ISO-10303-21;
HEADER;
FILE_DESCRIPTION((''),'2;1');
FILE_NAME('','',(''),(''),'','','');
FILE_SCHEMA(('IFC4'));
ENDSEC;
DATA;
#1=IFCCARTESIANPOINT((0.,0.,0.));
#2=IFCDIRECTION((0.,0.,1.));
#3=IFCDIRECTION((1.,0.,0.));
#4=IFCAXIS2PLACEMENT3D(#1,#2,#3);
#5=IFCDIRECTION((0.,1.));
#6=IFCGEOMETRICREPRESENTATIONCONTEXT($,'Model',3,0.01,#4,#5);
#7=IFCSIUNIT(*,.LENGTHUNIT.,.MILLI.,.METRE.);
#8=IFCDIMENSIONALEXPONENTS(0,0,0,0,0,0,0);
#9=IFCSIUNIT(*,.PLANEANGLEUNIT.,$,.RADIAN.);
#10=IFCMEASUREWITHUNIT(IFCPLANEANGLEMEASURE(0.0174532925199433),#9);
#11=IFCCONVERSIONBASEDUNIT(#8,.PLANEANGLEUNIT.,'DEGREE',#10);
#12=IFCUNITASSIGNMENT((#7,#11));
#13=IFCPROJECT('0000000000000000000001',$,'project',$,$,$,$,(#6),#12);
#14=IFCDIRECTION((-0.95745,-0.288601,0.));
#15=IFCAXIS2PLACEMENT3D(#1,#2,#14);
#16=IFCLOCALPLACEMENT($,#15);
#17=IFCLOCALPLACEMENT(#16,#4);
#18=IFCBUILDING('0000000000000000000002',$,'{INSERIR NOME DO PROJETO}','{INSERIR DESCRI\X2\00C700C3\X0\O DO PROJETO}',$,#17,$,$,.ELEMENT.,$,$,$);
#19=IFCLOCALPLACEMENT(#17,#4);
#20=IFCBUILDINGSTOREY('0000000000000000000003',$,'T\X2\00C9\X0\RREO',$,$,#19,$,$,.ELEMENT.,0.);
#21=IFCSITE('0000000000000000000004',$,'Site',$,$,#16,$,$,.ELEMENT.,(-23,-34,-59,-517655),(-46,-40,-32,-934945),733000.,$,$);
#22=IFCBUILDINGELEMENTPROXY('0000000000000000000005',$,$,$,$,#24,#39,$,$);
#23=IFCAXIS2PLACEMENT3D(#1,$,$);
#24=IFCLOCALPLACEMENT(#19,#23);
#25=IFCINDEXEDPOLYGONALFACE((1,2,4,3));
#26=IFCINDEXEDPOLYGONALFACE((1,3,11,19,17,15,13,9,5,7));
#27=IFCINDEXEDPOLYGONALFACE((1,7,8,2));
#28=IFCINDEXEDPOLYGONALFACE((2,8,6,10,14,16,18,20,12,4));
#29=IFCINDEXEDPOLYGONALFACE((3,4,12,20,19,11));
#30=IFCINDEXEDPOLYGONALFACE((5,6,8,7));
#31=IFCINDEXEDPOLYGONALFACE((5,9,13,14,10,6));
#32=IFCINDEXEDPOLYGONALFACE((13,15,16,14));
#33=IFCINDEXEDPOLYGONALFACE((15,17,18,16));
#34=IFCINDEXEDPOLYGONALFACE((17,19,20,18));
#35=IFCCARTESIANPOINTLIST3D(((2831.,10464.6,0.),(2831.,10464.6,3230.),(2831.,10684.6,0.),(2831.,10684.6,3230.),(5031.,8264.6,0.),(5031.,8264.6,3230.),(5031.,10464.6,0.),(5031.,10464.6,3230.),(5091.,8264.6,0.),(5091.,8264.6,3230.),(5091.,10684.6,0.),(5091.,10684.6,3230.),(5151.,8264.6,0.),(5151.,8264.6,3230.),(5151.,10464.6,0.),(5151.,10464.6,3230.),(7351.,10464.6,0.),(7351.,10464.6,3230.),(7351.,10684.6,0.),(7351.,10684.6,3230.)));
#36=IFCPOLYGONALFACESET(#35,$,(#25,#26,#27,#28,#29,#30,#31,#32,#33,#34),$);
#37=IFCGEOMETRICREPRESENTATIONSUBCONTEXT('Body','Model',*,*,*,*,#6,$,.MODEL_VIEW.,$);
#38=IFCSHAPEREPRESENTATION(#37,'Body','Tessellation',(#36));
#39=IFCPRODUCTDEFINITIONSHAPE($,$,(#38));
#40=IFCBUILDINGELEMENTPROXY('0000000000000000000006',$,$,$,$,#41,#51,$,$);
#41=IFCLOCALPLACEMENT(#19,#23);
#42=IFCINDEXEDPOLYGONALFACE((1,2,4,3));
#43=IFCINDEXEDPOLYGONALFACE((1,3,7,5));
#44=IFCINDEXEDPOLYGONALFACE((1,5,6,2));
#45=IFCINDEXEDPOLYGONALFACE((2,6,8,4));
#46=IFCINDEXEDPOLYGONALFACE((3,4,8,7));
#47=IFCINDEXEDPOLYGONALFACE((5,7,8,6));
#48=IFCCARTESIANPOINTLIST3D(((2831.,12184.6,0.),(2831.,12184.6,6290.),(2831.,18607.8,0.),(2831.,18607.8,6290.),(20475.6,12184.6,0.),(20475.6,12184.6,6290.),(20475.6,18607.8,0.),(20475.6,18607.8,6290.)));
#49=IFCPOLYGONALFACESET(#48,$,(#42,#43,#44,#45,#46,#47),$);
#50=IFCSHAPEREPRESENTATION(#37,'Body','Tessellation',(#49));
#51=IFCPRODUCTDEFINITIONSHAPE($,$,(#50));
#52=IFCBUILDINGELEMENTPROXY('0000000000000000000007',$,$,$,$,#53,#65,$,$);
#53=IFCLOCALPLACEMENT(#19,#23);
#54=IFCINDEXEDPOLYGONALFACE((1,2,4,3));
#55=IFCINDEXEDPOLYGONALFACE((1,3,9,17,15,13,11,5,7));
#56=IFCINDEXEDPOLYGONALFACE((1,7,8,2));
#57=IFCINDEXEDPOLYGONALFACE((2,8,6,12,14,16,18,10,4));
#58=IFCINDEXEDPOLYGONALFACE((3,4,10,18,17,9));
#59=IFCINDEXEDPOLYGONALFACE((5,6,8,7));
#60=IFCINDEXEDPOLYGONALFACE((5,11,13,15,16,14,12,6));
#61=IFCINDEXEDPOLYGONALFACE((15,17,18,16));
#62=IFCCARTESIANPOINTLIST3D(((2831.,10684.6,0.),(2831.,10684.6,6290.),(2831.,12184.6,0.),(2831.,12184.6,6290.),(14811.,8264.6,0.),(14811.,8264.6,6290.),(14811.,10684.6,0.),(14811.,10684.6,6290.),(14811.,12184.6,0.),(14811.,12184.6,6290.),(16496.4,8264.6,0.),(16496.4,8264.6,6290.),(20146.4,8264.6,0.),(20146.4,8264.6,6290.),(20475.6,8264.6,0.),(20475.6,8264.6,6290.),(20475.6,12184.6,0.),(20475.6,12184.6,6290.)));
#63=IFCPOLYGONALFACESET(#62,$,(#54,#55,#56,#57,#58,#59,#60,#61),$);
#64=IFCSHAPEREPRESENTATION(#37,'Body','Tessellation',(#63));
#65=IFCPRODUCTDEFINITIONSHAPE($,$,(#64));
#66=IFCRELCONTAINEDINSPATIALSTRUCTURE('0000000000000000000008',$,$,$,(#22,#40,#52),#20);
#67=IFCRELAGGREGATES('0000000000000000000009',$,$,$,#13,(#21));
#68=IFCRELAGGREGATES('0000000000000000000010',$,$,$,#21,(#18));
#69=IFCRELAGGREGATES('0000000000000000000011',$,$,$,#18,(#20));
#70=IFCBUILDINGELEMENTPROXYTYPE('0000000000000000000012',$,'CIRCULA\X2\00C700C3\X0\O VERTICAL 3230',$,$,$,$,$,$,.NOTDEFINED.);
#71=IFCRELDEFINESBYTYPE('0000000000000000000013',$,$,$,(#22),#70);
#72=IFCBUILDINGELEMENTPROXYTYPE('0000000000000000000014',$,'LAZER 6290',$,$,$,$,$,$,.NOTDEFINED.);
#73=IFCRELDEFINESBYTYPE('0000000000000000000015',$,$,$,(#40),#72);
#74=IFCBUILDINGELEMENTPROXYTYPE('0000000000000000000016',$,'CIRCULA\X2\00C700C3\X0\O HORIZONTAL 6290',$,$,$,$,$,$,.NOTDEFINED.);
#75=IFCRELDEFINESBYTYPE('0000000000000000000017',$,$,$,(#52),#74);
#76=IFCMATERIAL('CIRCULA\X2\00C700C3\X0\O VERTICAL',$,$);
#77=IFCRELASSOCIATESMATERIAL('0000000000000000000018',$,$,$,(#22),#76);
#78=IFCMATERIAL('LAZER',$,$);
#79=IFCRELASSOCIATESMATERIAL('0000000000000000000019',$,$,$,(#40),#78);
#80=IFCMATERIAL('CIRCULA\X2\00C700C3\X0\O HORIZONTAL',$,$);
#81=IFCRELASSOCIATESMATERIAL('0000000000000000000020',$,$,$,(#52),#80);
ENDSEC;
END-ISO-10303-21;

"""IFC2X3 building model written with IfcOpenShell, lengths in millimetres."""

from ifc_helpers import new_model, entity, si_unit, converted_unit, direction, frame, origin_with_axes, place, context, subcontext, project, spatial, polyline, outline, extrude, material, type_object, element, save


model = new_model("IFC2X3")

# Units and contexts
model_context = context("Model", 3, precision=0.01, world=origin_with_axes(), true_north=direction((0.0, 1.0)))
body_context = subcontext(model_context, "Body", "Model", "MODEL_VIEW")
ifc_project = project(units=[si_unit("LENGTHUNIT", "METRE", prefix="MILLI"), converted_unit("PLANEANGLEUNIT", "DEGREE", entity("IfcPlaneAngleMeasure", 0.0174532925199433), si_unit("PLANEANGLEUNIT", "RADIAN"), dimensions=[0, 0, 0, 0, 0, 0, 0])], contexts=[model_context])

# Site, building, storey
site_placement = place(None, frame((0.0, 0.0, 0.0), z_axis=(0.0, 0.0, 1.0), x_axis=(-0.95745, -0.288601, 0.0)))
site = spatial("IfcSite", under=ifc_project, at=site_placement, Name="Site", CompositionType="ELEMENT", RefLatitude=(-23, -34, -59, -517655), RefLongitude=(-46, -40, -32, -934945), RefElevation=733000.0)
building_placement = place(site_placement, origin_with_axes())
building = spatial("IfcBuilding", under=site, at=building_placement, Name="{INSERIR NOME DO PROJETO}", Description="{INSERIR DESCRIÇÃO DO PROJETO}", CompositionType="ELEMENT")
storey_placement = place(building_placement, origin_with_axes())
storey = spatial("IfcBuildingStorey", under=building, at=storey_placement, Name="TÉRREO", CompositionType="ELEMENT", Elevation=0.0)

# Building element proxies
ifc_material_1 = material(Name="CIRCULAÇÃO VERTICAL")
building_element_proxy_type_1 = type_object("IfcBuildingElementProxyType", Name="CIRCULAÇÃO VERTICAL 3230", PredefinedType="NOTDEFINED")
proxy_1_placement = place(storey_placement, frame((5091.0, 10684.6, 0.0), z_axis=(0.0, 0.0, 1.0), x_axis=(1.0, 0.0, 0.0)))
element("IfcBuildingElementProxy", 1, at=proxy_1_placement, inside=storey, type_object=building_element_proxy_type_1, material=ifc_material_1, context=body_context, shape_type="SweptSolid", body=[
    extrude(outline(polyline([(0.0, 0.0), (-2260.0, 0.0), (-2260.0, -220.0), (-60.0, -220.0), (-60.0, -2420.0), (0.0, -2420.0), (60.0, -2420.0), (60.0, -220.0), (2260.0, -220.0), (2260.0, 0.0), (0.0, 0.0)])), origin_with_axes(), (0.0, 0.0, 1.0), 3230.0),
])
ifc_material_2 = material(Name="LAZER")
building_element_proxy_type_2 = type_object("IfcBuildingElementProxyType", Name="LAZER 6290", PredefinedType="NOTDEFINED")
proxy_2_placement = place(storey_placement, frame((2831.0, 12184.6, 0.0), z_axis=(0.0, 0.0, 1.0), x_axis=(1.0, 0.0, 0.0)))
element("IfcBuildingElementProxy", 2, at=proxy_2_placement, inside=storey, type_object=building_element_proxy_type_2, material=ifc_material_2, context=body_context, shape_type="SweptSolid", body=[
    extrude(outline(polyline([(0.0, 0.0), (17644.6, 0.0), (17644.6, 6423.2), (0.0, 6423.2), (0.0, 0.0)])), origin_with_axes(), (0.0, 0.0, 1.0), 6290.0),
])
ifc_material_3 = material(Name="CIRCULAÇÃO HORIZONTAL")
building_element_proxy_type_3 = type_object("IfcBuildingElementProxyType", Name="CIRCULAÇÃO HORIZONTAL 6290", PredefinedType="NOTDEFINED")
proxy_3_placement = place(storey_placement, frame((2831.0, 12184.6, 0.0), z_axis=(0.0, 0.0, 1.0), x_axis=(1.0, 0.0, 0.0)))
element("IfcBuildingElementProxy", 3, at=proxy_3_placement, inside=storey, type_object=building_element_proxy_type_3, material=ifc_material_3, context=body_context, shape_type="SweptSolid", body=[
    extrude(outline(polyline([(0.0, 0.0), (0.0, -1500.0), (11980.0, -1500.0), (11980.0, -3920.0), (13665.4, -3920.0), (17315.4, -3920.0), (17644.6, -3920.0), (17644.6, 0.0), (11980.0, 0.0), (0.0, 0.0)])), origin_with_axes(), (0.0, 0.0, 1.0), 6290.0),
])

save(model, "model.ifc")
